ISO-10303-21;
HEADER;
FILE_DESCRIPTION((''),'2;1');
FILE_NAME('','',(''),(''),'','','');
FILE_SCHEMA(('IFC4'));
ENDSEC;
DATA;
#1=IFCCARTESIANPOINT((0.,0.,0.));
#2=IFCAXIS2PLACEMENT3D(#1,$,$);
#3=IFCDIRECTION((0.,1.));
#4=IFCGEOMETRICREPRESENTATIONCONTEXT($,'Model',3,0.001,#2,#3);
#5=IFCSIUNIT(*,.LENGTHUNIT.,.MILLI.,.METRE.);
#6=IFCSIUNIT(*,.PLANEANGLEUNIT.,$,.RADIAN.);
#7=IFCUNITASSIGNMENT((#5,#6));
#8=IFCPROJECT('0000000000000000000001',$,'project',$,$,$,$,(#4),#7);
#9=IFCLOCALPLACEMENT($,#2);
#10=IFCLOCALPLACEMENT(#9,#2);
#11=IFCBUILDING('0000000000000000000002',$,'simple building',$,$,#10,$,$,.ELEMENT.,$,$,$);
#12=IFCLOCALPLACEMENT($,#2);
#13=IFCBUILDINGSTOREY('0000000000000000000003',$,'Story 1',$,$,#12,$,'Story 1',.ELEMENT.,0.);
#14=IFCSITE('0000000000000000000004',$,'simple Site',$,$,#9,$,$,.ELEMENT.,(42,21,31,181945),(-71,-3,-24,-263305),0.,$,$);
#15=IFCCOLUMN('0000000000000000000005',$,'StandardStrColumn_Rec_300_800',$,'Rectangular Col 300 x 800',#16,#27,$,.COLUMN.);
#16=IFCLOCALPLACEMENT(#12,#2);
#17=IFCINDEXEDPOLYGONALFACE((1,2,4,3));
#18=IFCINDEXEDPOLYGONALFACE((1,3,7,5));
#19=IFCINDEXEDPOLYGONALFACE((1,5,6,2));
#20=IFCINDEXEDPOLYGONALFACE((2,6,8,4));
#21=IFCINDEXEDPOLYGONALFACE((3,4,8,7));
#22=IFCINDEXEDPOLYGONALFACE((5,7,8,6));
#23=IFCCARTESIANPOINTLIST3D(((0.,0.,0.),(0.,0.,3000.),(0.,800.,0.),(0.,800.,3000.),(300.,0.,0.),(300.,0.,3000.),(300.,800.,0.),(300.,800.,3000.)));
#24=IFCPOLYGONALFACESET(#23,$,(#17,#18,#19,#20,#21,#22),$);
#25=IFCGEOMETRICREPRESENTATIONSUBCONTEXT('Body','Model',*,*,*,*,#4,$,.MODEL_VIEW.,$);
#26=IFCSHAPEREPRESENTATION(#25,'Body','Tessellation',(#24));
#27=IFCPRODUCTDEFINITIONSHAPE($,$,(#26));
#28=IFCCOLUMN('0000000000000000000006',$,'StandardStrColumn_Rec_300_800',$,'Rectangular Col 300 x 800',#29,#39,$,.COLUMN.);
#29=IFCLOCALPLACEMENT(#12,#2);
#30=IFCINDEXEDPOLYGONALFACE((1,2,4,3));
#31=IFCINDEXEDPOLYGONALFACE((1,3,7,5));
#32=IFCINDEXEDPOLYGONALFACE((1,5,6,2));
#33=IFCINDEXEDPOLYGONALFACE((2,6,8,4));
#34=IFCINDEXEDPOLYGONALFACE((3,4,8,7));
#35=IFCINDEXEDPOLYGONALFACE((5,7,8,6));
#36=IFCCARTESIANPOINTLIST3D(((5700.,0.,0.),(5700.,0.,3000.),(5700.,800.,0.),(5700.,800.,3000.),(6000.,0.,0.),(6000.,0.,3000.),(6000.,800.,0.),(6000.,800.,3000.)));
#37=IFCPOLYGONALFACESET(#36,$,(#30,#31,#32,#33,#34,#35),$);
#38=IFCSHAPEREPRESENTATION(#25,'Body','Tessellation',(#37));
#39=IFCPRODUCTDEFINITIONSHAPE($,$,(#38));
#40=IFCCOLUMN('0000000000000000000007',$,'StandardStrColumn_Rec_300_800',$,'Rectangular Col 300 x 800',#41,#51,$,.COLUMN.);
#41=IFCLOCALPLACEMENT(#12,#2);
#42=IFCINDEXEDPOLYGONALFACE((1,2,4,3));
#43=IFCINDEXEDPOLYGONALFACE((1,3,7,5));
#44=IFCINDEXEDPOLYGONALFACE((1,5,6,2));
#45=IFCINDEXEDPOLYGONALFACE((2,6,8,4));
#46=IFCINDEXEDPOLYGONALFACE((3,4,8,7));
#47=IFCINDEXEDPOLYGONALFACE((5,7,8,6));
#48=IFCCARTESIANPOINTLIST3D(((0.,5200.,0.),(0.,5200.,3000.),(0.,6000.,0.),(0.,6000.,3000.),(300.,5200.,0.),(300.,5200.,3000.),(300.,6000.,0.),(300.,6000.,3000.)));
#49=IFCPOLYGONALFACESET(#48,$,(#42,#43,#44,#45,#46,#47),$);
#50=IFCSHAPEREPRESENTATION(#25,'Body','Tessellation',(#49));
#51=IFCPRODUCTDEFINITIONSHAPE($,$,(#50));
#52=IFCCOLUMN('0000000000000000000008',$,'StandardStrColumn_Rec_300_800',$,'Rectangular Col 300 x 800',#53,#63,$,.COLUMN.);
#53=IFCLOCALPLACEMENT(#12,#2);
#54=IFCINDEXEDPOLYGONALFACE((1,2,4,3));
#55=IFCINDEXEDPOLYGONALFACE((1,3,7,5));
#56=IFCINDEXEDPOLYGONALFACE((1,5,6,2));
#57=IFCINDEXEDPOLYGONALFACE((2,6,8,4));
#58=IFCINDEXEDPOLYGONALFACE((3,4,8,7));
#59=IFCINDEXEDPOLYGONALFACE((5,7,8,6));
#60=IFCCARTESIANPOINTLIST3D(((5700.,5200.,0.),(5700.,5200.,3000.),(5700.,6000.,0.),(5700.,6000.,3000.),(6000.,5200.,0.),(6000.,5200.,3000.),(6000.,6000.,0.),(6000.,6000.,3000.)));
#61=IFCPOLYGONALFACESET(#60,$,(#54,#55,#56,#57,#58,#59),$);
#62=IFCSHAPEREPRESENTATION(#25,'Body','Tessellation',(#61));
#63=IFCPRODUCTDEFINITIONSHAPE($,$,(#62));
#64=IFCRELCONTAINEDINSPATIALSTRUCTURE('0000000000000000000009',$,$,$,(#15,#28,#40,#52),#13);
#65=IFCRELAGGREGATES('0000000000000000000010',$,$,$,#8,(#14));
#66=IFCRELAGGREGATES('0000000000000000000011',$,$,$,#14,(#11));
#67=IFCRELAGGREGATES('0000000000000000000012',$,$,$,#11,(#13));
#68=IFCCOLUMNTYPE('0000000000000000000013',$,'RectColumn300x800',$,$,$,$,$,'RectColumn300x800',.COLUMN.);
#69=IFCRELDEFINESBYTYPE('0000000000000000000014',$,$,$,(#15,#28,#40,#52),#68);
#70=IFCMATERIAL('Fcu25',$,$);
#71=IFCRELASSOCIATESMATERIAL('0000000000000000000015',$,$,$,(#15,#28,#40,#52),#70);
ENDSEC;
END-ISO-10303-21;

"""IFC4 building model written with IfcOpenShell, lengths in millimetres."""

from ifc_helpers import new_model, si_unit, direction, frame, origin, origin_with_axes, origin_2d_with_axis, place, context, subcontext, project, spatial, rectangle, extrude, material, material_profile, profile_set, profile_usage, type_object, element, save


model = new_model("IFC4")

# Units and contexts
model_context = context("Model", 3, precision=0.001, world=origin(), true_north=direction((0.0, 1.0)))
body_context = subcontext(model_context, "Body", "Model", "MODEL_VIEW")
ifc_project = project(units=[si_unit("LENGTHUNIT", "METRE", prefix="MILLI"), si_unit("PLANEANGLEUNIT", "RADIAN")], contexts=[model_context])

# Site, building, storey
site_placement = place(None, origin())
site = spatial("IfcSite", under=ifc_project, at=site_placement, Name="simple Site", CompositionType="ELEMENT", RefLatitude=(42, 21, 31, 181945), RefLongitude=(-71, -3, -24, -263305), RefElevation=0.0)
building_placement = place(site_placement, origin())
building = spatial("IfcBuilding", under=site, at=building_placement, Name="simple building", CompositionType="ELEMENT")
storey_placement = place(None, origin())
storey = spatial("IfcBuildingStorey", under=building, at=storey_placement, Name="Story 1", LongName="Story 1", CompositionType="ELEMENT", Elevation=0.0)

# Columns
ifc_material = material(Name="Fcu25")
ifc_material_profile = material_profile(ifc_material, rectangle(XDim=300.0, YDim=800.0, at=origin_2d_with_axis()))
ifc_profile_set = profile_set([ifc_material_profile])
ifc_profile_usage_1 = profile_usage(ifc_profile_set, cardinal=7)
column_type = type_object("IfcColumnType", Name="RectColumn300x800", ElementType="RectColumn300x800", PredefinedType="COLUMN")
column_1_placement = place(None, frame((150.0, 400.0, 0.0), z_axis=(0.0, 0.0, 1.0), x_axis=(1.0, 0.0, 0.0)))
element("IfcColumn", 1, at=column_1_placement, inside=storey, type_object=column_type, material=ifc_profile_usage_1, Name="StandardStrColumn_Rec_300_800", ObjectType="Rectangular Col 300 x 800", PredefinedType="COLUMN", context=body_context, shape_type="SweptSolid", body=[
    extrude(rectangle(XDim=300.0, YDim=800.0, at=origin_2d_with_axis()), origin_with_axes(), (0.0, 0.0, 1.0), 3000.0),
])
ifc_profile_usage_2 = profile_usage(ifc_profile_set, cardinal=9)
column_2_placement = place(None, frame((5850.0, 400.0, 0.0), z_axis=(0.0, 0.0, 1.0), x_axis=(1.0, 0.0, 0.0)))
element("IfcColumn", 2, at=column_2_placement, inside=storey, type_object=column_type, material=ifc_profile_usage_2, Name="StandardStrColumn_Rec_300_800", ObjectType="Rectangular Col 300 x 800", PredefinedType="COLUMN", context=body_context, shape_type="SweptSolid", body=[
    extrude(rectangle(XDim=300.0, YDim=800.0, at=origin_2d_with_axis()), origin_with_axes(), (0.0, 0.0, 1.0), 3000.0),
])
ifc_profile_usage_3 = profile_usage(ifc_profile_set, cardinal=1)
column_3_placement = place(None, frame((150.0, 5600.0, 0.0), z_axis=(0.0, 0.0, 1.0), x_axis=(1.0, 0.0, 0.0)))
element("IfcColumn", 3, at=column_3_placement, inside=storey, type_object=column_type, material=ifc_profile_usage_3, Name="StandardStrColumn_Rec_300_800", ObjectType="Rectangular Col 300 x 800", PredefinedType="COLUMN", context=body_context, shape_type="SweptSolid", body=[
    extrude(rectangle(XDim=300.0, YDim=800.0, at=origin_2d_with_axis()), origin_with_axes(), (0.0, 0.0, 1.0), 3000.0),
])
ifc_profile_usage_4 = profile_usage(ifc_profile_set, cardinal=3)
column_4_placement = place(None, frame((5850.0, 5600.0, 0.0), z_axis=(0.0, 0.0, 1.0), x_axis=(1.0, 0.0, 0.0)))
element("IfcColumn", 4, at=column_4_placement, inside=storey, type_object=column_type, material=ifc_profile_usage_4, Name="StandardStrColumn_Rec_300_800", ObjectType="Rectangular Col 300 x 800", PredefinedType="COLUMN", context=body_context, shape_type="SweptSolid", body=[
    extrude(rectangle(XDim=300.0, YDim=800.0, at=origin_2d_with_axis()), origin_with_axes(), (0.0, 0.0, 1.0), 3000.0),
])

save(model, "model.ifc")
